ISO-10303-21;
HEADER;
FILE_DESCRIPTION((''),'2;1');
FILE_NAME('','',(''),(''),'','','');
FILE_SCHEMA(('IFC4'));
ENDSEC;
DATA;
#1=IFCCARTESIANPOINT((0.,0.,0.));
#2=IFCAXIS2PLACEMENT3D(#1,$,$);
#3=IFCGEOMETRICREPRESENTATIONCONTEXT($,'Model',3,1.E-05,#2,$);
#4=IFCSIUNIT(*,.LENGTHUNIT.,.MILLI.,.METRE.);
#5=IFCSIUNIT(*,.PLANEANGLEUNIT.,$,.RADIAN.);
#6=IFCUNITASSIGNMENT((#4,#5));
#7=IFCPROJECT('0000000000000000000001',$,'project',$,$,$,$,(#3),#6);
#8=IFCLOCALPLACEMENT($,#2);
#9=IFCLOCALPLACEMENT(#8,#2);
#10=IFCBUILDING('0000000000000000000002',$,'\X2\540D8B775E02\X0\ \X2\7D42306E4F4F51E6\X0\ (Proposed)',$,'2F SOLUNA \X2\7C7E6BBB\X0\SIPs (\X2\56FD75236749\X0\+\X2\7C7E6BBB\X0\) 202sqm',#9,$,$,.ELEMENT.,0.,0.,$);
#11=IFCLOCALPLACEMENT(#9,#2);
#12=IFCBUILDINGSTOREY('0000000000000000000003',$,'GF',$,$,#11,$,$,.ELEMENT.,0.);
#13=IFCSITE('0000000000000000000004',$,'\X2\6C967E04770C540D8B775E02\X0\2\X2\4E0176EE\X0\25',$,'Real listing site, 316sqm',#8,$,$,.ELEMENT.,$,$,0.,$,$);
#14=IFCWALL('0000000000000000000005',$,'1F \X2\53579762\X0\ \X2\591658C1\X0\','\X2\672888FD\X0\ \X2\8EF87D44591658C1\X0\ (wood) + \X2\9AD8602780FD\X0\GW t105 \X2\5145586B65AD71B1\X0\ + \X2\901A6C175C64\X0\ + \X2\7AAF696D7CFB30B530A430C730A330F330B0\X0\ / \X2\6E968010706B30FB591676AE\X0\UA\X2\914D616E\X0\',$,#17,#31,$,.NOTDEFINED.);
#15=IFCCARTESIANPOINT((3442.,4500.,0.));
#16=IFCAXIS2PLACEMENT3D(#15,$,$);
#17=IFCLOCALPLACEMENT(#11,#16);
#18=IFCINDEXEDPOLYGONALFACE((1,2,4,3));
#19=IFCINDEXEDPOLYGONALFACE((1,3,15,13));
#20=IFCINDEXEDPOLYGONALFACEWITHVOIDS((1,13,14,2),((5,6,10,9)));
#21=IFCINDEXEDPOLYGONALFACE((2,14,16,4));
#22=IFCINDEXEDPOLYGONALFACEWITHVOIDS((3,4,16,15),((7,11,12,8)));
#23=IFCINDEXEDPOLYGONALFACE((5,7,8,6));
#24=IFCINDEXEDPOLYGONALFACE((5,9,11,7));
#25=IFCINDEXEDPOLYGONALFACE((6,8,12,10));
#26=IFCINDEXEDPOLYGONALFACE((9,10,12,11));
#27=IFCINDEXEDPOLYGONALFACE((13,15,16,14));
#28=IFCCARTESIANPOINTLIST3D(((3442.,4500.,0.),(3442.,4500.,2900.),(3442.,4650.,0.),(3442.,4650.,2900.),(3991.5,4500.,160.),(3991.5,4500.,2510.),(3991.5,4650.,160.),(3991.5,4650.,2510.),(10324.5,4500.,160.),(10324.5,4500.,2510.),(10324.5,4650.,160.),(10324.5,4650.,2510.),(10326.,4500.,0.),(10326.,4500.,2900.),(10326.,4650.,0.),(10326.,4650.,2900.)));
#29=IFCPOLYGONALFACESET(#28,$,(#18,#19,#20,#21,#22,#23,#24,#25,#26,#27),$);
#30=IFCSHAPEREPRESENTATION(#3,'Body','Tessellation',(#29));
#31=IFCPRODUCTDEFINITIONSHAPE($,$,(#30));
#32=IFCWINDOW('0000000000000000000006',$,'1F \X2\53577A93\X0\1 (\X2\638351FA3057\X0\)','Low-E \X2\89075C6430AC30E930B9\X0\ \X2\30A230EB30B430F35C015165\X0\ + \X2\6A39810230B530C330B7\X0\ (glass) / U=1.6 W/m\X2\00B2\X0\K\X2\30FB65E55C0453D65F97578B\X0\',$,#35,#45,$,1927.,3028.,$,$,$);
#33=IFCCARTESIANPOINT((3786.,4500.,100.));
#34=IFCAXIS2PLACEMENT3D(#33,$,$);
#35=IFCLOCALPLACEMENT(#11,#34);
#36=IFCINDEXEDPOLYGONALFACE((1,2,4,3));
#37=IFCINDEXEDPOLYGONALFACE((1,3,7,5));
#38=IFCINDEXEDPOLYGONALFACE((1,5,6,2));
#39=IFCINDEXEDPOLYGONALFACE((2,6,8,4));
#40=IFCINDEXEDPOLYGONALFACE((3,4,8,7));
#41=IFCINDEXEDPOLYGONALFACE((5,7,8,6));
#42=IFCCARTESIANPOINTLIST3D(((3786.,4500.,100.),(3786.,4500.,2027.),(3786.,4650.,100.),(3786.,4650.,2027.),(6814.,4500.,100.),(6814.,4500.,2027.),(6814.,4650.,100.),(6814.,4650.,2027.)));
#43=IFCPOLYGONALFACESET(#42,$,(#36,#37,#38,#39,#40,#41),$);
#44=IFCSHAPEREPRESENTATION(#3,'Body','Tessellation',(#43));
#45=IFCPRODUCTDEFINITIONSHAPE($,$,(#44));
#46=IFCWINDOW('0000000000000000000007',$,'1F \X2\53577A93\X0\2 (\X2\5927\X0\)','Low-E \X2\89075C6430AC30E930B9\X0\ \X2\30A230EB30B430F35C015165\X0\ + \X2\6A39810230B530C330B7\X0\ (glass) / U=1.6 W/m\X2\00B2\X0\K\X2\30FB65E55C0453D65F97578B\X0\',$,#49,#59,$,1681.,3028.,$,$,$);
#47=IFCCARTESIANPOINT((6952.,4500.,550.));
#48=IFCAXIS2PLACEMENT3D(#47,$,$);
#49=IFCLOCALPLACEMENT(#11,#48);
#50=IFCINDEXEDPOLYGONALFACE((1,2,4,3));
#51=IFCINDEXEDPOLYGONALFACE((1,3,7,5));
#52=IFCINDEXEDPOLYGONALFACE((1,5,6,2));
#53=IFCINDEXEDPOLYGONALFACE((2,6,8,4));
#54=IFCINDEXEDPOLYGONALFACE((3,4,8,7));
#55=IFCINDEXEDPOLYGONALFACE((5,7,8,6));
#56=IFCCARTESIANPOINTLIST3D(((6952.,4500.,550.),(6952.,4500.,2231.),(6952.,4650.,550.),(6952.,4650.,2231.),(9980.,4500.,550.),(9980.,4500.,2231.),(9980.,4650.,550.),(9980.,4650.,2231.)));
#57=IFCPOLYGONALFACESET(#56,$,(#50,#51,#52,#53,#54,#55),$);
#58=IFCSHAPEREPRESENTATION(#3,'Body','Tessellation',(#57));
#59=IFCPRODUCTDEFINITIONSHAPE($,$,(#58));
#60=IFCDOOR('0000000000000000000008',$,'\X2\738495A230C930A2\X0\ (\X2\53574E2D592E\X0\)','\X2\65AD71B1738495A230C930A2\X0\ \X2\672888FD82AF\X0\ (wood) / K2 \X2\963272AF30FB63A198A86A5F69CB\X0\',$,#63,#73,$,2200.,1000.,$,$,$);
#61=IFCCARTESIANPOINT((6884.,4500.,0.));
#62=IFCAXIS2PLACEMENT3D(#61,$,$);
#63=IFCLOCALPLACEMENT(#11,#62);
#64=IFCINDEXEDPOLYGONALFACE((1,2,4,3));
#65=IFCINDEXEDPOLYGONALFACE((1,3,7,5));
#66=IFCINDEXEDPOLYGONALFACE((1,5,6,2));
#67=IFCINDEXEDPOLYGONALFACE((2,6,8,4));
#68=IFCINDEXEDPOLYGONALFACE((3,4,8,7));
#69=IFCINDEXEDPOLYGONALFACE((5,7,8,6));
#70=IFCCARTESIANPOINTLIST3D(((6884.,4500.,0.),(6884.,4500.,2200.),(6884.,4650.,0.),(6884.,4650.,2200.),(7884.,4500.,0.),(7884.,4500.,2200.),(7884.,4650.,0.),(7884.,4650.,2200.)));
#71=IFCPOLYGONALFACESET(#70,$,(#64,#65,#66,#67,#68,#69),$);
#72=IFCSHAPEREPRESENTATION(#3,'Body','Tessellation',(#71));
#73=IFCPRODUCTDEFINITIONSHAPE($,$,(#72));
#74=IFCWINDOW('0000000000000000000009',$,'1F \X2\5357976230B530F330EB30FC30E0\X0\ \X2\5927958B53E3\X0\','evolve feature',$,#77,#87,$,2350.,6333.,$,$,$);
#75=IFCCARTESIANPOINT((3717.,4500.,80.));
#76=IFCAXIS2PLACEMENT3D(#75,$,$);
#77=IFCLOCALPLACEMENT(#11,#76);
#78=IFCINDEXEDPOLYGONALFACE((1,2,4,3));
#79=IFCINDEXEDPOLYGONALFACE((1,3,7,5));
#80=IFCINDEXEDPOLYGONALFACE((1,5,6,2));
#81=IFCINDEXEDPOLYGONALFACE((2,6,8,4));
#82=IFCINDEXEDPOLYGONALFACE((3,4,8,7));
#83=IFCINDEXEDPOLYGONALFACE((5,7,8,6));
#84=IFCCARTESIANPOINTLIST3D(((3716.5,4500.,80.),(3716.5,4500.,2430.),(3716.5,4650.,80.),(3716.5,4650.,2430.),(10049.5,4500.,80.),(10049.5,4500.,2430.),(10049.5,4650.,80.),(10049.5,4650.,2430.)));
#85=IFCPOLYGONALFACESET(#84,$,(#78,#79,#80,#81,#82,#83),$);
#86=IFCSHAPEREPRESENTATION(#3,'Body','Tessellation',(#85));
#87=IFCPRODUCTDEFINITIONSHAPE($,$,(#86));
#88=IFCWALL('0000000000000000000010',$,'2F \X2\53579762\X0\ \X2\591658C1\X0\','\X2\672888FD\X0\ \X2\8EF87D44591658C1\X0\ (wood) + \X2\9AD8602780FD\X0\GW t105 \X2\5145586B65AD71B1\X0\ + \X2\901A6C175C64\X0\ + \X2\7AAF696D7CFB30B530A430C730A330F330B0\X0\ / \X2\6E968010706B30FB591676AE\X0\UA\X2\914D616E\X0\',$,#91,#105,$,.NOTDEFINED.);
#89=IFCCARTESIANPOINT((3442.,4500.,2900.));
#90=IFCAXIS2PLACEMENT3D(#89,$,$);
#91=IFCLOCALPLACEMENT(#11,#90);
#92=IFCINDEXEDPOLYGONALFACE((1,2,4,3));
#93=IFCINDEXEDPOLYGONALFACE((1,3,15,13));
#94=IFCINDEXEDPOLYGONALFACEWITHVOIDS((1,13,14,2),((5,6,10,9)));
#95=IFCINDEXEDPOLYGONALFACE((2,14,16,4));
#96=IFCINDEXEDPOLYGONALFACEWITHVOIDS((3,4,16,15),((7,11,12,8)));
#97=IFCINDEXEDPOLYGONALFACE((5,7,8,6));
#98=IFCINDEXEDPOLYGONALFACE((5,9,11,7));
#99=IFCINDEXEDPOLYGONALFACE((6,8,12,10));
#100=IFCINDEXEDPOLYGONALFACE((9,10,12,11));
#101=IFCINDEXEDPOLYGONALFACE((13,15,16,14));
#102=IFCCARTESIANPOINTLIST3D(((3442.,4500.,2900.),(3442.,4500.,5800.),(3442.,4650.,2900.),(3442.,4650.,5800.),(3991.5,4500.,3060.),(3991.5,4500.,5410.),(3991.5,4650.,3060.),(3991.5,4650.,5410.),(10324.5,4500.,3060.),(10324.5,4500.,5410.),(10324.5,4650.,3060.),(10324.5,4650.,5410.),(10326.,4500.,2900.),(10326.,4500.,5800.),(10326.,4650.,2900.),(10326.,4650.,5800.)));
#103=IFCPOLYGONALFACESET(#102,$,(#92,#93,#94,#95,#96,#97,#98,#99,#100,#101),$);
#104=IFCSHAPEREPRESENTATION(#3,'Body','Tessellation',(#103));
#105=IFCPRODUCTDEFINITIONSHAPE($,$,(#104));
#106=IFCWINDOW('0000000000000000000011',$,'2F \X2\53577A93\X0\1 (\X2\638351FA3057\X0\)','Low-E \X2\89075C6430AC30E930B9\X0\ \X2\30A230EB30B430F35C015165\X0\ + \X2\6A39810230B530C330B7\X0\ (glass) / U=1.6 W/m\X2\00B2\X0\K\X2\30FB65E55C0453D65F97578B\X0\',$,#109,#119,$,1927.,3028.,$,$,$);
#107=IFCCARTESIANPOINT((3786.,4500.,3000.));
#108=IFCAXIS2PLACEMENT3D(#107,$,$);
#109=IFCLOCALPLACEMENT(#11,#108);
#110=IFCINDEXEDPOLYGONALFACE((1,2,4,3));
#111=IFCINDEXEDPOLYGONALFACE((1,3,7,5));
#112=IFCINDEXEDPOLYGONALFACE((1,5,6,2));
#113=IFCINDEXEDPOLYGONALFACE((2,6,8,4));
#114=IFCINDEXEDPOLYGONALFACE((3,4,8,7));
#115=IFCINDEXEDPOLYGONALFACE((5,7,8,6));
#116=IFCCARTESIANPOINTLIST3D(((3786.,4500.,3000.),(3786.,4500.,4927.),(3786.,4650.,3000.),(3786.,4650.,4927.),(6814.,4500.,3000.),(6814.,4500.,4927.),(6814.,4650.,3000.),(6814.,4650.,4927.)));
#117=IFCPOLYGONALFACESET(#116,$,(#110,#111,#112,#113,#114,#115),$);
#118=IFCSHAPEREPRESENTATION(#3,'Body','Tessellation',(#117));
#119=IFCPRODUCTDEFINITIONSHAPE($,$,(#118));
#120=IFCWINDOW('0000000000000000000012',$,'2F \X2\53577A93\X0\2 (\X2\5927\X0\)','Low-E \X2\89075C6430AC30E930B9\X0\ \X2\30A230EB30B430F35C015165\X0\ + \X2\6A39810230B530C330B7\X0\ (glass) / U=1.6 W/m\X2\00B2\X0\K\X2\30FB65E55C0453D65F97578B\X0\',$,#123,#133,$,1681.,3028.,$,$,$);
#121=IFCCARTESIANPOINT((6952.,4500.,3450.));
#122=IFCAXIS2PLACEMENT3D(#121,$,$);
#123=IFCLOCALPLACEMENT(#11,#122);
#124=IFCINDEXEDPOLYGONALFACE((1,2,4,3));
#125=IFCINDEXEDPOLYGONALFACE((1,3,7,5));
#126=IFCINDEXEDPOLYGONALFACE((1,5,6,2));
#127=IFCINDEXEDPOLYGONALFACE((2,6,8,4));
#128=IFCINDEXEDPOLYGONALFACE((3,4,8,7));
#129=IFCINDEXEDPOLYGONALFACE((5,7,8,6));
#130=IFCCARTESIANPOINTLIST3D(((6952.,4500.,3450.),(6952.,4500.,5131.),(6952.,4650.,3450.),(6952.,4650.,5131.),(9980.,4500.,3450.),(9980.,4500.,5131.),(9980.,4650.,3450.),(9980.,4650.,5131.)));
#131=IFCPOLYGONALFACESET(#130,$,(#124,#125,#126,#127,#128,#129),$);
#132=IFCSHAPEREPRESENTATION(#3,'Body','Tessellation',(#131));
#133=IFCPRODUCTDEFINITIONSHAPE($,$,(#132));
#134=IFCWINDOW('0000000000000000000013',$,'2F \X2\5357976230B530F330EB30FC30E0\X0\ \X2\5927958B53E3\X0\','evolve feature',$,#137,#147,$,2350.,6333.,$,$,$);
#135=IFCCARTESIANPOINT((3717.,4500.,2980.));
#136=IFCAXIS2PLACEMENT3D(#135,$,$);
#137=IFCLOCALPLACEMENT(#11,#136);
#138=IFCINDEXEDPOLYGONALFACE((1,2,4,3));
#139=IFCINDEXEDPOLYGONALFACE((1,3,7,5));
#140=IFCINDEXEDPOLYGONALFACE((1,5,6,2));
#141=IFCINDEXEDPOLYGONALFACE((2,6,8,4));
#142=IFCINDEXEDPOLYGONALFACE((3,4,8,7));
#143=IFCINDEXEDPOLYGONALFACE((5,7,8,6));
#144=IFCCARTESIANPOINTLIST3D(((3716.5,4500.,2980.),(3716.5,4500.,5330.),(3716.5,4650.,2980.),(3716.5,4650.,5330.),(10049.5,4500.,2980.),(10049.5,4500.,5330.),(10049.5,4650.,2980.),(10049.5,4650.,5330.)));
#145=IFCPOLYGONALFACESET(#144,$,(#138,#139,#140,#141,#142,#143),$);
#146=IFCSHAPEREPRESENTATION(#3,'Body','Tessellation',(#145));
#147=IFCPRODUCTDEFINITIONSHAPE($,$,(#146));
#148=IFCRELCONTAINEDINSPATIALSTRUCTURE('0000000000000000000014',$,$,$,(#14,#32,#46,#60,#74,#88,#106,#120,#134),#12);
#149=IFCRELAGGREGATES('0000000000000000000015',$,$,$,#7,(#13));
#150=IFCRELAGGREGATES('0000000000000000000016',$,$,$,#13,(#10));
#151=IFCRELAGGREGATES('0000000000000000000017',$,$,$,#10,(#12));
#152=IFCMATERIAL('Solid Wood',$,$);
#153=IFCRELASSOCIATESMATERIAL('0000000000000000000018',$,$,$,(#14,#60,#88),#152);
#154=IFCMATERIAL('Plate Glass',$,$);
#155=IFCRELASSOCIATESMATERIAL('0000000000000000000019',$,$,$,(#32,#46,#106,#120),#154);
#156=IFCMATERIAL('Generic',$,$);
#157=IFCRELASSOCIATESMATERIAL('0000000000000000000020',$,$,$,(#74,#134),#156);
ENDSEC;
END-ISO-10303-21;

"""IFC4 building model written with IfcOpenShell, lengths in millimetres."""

from ifc_helpers import new_model, si_unit, frame, frame_2d, origin, place, context, project, spatial, rectangle, extrude, material, element, fill, save


model = new_model("IFC4")

# Units and contexts
model_context = context("Model", 3, precision=1e-05, world=origin())
ifc_project = project(units=[si_unit("LENGTHUNIT", "METRE", prefix="MILLI"), si_unit("PLANEANGLEUNIT", "RADIAN")], contexts=[model_context])

# Site, building, storey
site_placement = place(None, origin())
site = spatial("IfcSite", under=ifc_project, at=site_placement, Name="沖縄県名護市2丁目25", ObjectType="Real listing site, 316sqm", CompositionType="ELEMENT", RefElevation=0.0)
building_placement = place(site_placement, origin())
building = spatial("IfcBuilding", under=site, at=building_placement, Name="名護市 終の住処 (Proposed)", ObjectType="2F SOLUNA 籾殻SIPs (国産杉+籾殻) 202sqm", CompositionType="ELEMENT", ElevationOfRefHeight=0.0, ElevationOfTerrain=0.0)
storey_placement = place(building_placement, origin())
storey = spatial("IfcBuildingStorey", under=building, at=storey_placement, Name="GF", CompositionType="ELEMENT", Elevation=0.0)

# Shared definitions
ifc_material_1 = material(Name="Solid Wood")
ifc_material_2 = material(Name="Generic")

# Wall, openings, windows, door
wall_1_placement = place(storey_placement, frame((3442.0, 4500.0, 0.0)))
wall_1 = element("IfcWall", 1, at=wall_1_placement, inside=storey, material=ifc_material_1, Name="1F 南面 外壁", Description="木製 軸組外壁 (wood) + 高性能GW t105 充填断熱 + 通気層 + 窯業系サイディング / 準耐火・外皮UA配慮", PredefinedType="NOTDEFINED", context=model_context, shape_type="SweptSolid", body=[
    extrude(rectangle(XDim=6884.0, YDim=150.0, at=frame_2d((3442.0, 75.0))), frame((3442.0, 4500.0, 0.0)), (0.0, 0.0, 1.0), 2900.0),
])
opening_1_placement = place(storey_placement, frame((3786.0, 4500.0, 100.0)))
opening_1 = element("IfcOpeningElement", 2, at=opening_1_placement, cuts=wall_1, PredefinedType="NOTDEFINED", context=model_context, shape_type="SweptSolid", body=[
    extrude(rectangle(XDim=3028.0, YDim=150.0, at=frame_2d((1514.0, 75.0))), frame((3786.0, 4500.0, 100.0)), (0.0, 0.0, 1.0), 1927.0),
])
opening_2_placement = place(storey_placement, frame((6952.0, 4500.0, 550.0)))
opening_2 = element("IfcOpeningElement", 3, at=opening_2_placement, cuts=wall_1, PredefinedType="NOTDEFINED", context=model_context, shape_type="SweptSolid", body=[
    extrude(rectangle(XDim=3028.0, YDim=150.0, at=frame_2d((1514.0, 75.0))), frame((6952.0, 4500.0, 550.0)), (0.0, 0.0, 1.0), 1681.0),
])
opening_3_placement = place(storey_placement, frame((6884.0, 4500.0, 0.0)))
opening_3 = element("IfcOpeningElement", 4, at=opening_3_placement, cuts=wall_1, PredefinedType="NOTDEFINED", context=model_context, shape_type="SweptSolid", body=[
    extrude(rectangle(XDim=1000.0, YDim=150.0, at=frame_2d((500.0, 75.0))), frame((6884.0, 4500.0, 0.0)), (0.0, 0.0, 1.0), 2200.0),
])
opening_4_placement = place(storey_placement, frame((3717.0, 4500.0, 80.0)))
opening_4 = element("IfcOpeningElement", 5, at=opening_4_placement, cuts=wall_1, PredefinedType="NOTDEFINED", context=model_context, shape_type="SweptSolid", body=[
    extrude(rectangle(XDim=6333.0, YDim=150.0, at=frame_2d((3166.0, 75.0))), frame((3717.0, 4500.0, 80.0)), (0.0, 0.0, 1.0), 2350.0),
])
ifc_material_3 = material(Name="Plate Glass")
window_1_placement = place(storey_placement, frame((3786.0, 4500.0, 100.0)))
window_1 = element("IfcWindow", 6, at=window_1_placement, inside=storey, material=ifc_material_3, Name="1F 南窓1 (掃出し)", Description="Low-E 複層ガラス アルゴン封入 + 樹脂サッシ (glass) / U=1.6 W/m²K・日射取得型", OverallHeight=1927.0, OverallWidth=3028.0, context=model_context, shape_type="SweptSolid", body=[
    extrude(rectangle(XDim=3028.0, YDim=150.0, at=frame_2d((1514.0, 75.0))), frame((3786.0, 4500.0, 100.0)), (0.0, 0.0, 1.0), 1927.0),
])
fill(opening_1, window_1)
window_2_placement = place(storey_placement, frame((6952.0, 4500.0, 550.0)))
window_2 = element("IfcWindow", 7, at=window_2_placement, inside=storey, material=ifc_material_3, Name="1F 南窓2 (大)", Description="Low-E 複層ガラス アルゴン封入 + 樹脂サッシ (glass) / U=1.6 W/m²K・日射取得型", OverallHeight=1681.0, OverallWidth=3028.0, context=model_context, shape_type="SweptSolid", body=[
    extrude(rectangle(XDim=3028.0, YDim=150.0, at=frame_2d((1514.0, 75.0))), frame((6952.0, 4500.0, 550.0)), (0.0, 0.0, 1.0), 1681.0),
])
fill(opening_2, window_2)
door_placement = place(storey_placement, frame((6884.0, 4500.0, 0.0)))
door = element("IfcDoor", 8, at=door_placement, inside=storey, material=ifc_material_1, Name="玄関ドア (南中央)", Description="断熱玄関ドア 木製芯 (wood) / K2 防犯・採風機構", OverallHeight=2200.0, OverallWidth=1000.0, context=model_context, shape_type="SweptSolid", body=[
    extrude(rectangle(XDim=1000.0, YDim=150.0, at=frame_2d((500.0, 75.0))), frame((6884.0, 4500.0, 0.0)), (0.0, 0.0, 1.0), 2200.0),
])
fill(opening_3, door)
window_3_placement = place(storey_placement, frame((3717.0, 4500.0, 80.0)))
window_3 = element("IfcWindow", 9, at=window_3_placement, inside=storey, material=ifc_material_2, Name="1F 南面サンルーム 大開口", Description="evolve feature", OverallHeight=2350.0, OverallWidth=6333.0, context=model_context, shape_type="SweptSolid", body=[
    extrude(rectangle(XDim=6333.0, YDim=150.0, at=frame_2d((3166.0, 75.0))), frame((3717.0, 4500.0, 80.0)), (0.0, 0.0, 1.0), 2350.0),
])
fill(opening_4, window_3)

# Wall, openings, windows
wall_2_placement = place(storey_placement, frame((3442.0, 4500.0, 2900.0)))
wall_2 = element("IfcWall", 10, at=wall_2_placement, inside=storey, material=ifc_material_1, Name="2F 南面 外壁", Description="木製 軸組外壁 (wood) + 高性能GW t105 充填断熱 + 通気層 + 窯業系サイディング / 準耐火・外皮UA配慮", PredefinedType="NOTDEFINED", context=model_context, shape_type="SweptSolid", body=[
    extrude(rectangle(XDim=6884.0, YDim=150.0, at=frame_2d((3442.0, 75.0))), frame((3442.0, 4500.0, 2900.0)), (0.0, 0.0, 1.0), 2900.0),
])
opening_5_placement = place(storey_placement, frame((3786.0, 4500.0, 3000.0)))
opening_5 = element("IfcOpeningElement", 11, at=opening_5_placement, cuts=wall_2, PredefinedType="NOTDEFINED", context=model_context, shape_type="SweptSolid", body=[
    extrude(rectangle(XDim=3028.0, YDim=150.0, at=frame_2d((1514.0, 75.0))), frame((3786.0, 4500.0, 3000.0)), (0.0, 0.0, 1.0), 1927.0),
])
opening_6_placement = place(storey_placement, frame((6952.0, 4500.0, 3450.0)))
opening_6 = element("IfcOpeningElement", 12, at=opening_6_placement, cuts=wall_2, PredefinedType="NOTDEFINED", context=model_context, shape_type="SweptSolid", body=[
    extrude(rectangle(XDim=3028.0, YDim=150.0, at=frame_2d((1514.0, 75.0))), frame((6952.0, 4500.0, 3450.0)), (0.0, 0.0, 1.0), 1681.0),
])
opening_7_placement = place(storey_placement, frame((3717.0, 4500.0, 2980.0)))
opening_7 = element("IfcOpeningElement", 13, at=opening_7_placement, cuts=wall_2, PredefinedType="NOTDEFINED", context=model_context, shape_type="SweptSolid", body=[
    extrude(rectangle(XDim=6333.0, YDim=150.0, at=frame_2d((3166.0, 75.0))), frame((3717.0, 4500.0, 2980.0)), (0.0, 0.0, 1.0), 2350.0),
])
window_4_placement = place(storey_placement, frame((3786.0, 4500.0, 3000.0)))
window_4 = element("IfcWindow", 14, at=window_4_placement, inside=storey, material=ifc_material_3, Name="2F 南窓1 (掃出し)", Description="Low-E 複層ガラス アルゴン封入 + 樹脂サッシ (glass) / U=1.6 W/m²K・日射取得型", OverallHeight=1927.0, OverallWidth=3028.0, context=model_context, shape_type="SweptSolid", body=[
    extrude(rectangle(XDim=3028.0, YDim=150.0, at=frame_2d((1514.0, 75.0))), frame((3786.0, 4500.0, 3000.0)), (0.0, 0.0, 1.0), 1927.0),
])
fill(opening_5, window_4)
window_5_placement = place(storey_placement, frame((6952.0, 4500.0, 3450.0)))
window_5 = element("IfcWindow", 15, at=window_5_placement, inside=storey, material=ifc_material_3, Name="2F 南窓2 (大)", Description="Low-E 複層ガラス アルゴン封入 + 樹脂サッシ (glass) / U=1.6 W/m²K・日射取得型", OverallHeight=1681.0, OverallWidth=3028.0, context=model_context, shape_type="SweptSolid", body=[
    extrude(rectangle(XDim=3028.0, YDim=150.0, at=frame_2d((1514.0, 75.0))), frame((6952.0, 4500.0, 3450.0)), (0.0, 0.0, 1.0), 1681.0),
])
fill(opening_6, window_5)
window_6_placement = place(storey_placement, frame((3717.0, 4500.0, 2980.0)))
window_6 = element("IfcWindow", 16, at=window_6_placement, inside=storey, material=ifc_material_2, Name="2F 南面サンルーム 大開口", Description="evolve feature", OverallHeight=2350.0, OverallWidth=6333.0, context=model_context, shape_type="SweptSolid", body=[
    extrude(rectangle(XDim=6333.0, YDim=150.0, at=frame_2d((3166.0, 75.0))), frame((3717.0, 4500.0, 2980.0)), (0.0, 0.0, 1.0), 2350.0),
])
fill(opening_7, window_6)

save(model, "model.ifc")
